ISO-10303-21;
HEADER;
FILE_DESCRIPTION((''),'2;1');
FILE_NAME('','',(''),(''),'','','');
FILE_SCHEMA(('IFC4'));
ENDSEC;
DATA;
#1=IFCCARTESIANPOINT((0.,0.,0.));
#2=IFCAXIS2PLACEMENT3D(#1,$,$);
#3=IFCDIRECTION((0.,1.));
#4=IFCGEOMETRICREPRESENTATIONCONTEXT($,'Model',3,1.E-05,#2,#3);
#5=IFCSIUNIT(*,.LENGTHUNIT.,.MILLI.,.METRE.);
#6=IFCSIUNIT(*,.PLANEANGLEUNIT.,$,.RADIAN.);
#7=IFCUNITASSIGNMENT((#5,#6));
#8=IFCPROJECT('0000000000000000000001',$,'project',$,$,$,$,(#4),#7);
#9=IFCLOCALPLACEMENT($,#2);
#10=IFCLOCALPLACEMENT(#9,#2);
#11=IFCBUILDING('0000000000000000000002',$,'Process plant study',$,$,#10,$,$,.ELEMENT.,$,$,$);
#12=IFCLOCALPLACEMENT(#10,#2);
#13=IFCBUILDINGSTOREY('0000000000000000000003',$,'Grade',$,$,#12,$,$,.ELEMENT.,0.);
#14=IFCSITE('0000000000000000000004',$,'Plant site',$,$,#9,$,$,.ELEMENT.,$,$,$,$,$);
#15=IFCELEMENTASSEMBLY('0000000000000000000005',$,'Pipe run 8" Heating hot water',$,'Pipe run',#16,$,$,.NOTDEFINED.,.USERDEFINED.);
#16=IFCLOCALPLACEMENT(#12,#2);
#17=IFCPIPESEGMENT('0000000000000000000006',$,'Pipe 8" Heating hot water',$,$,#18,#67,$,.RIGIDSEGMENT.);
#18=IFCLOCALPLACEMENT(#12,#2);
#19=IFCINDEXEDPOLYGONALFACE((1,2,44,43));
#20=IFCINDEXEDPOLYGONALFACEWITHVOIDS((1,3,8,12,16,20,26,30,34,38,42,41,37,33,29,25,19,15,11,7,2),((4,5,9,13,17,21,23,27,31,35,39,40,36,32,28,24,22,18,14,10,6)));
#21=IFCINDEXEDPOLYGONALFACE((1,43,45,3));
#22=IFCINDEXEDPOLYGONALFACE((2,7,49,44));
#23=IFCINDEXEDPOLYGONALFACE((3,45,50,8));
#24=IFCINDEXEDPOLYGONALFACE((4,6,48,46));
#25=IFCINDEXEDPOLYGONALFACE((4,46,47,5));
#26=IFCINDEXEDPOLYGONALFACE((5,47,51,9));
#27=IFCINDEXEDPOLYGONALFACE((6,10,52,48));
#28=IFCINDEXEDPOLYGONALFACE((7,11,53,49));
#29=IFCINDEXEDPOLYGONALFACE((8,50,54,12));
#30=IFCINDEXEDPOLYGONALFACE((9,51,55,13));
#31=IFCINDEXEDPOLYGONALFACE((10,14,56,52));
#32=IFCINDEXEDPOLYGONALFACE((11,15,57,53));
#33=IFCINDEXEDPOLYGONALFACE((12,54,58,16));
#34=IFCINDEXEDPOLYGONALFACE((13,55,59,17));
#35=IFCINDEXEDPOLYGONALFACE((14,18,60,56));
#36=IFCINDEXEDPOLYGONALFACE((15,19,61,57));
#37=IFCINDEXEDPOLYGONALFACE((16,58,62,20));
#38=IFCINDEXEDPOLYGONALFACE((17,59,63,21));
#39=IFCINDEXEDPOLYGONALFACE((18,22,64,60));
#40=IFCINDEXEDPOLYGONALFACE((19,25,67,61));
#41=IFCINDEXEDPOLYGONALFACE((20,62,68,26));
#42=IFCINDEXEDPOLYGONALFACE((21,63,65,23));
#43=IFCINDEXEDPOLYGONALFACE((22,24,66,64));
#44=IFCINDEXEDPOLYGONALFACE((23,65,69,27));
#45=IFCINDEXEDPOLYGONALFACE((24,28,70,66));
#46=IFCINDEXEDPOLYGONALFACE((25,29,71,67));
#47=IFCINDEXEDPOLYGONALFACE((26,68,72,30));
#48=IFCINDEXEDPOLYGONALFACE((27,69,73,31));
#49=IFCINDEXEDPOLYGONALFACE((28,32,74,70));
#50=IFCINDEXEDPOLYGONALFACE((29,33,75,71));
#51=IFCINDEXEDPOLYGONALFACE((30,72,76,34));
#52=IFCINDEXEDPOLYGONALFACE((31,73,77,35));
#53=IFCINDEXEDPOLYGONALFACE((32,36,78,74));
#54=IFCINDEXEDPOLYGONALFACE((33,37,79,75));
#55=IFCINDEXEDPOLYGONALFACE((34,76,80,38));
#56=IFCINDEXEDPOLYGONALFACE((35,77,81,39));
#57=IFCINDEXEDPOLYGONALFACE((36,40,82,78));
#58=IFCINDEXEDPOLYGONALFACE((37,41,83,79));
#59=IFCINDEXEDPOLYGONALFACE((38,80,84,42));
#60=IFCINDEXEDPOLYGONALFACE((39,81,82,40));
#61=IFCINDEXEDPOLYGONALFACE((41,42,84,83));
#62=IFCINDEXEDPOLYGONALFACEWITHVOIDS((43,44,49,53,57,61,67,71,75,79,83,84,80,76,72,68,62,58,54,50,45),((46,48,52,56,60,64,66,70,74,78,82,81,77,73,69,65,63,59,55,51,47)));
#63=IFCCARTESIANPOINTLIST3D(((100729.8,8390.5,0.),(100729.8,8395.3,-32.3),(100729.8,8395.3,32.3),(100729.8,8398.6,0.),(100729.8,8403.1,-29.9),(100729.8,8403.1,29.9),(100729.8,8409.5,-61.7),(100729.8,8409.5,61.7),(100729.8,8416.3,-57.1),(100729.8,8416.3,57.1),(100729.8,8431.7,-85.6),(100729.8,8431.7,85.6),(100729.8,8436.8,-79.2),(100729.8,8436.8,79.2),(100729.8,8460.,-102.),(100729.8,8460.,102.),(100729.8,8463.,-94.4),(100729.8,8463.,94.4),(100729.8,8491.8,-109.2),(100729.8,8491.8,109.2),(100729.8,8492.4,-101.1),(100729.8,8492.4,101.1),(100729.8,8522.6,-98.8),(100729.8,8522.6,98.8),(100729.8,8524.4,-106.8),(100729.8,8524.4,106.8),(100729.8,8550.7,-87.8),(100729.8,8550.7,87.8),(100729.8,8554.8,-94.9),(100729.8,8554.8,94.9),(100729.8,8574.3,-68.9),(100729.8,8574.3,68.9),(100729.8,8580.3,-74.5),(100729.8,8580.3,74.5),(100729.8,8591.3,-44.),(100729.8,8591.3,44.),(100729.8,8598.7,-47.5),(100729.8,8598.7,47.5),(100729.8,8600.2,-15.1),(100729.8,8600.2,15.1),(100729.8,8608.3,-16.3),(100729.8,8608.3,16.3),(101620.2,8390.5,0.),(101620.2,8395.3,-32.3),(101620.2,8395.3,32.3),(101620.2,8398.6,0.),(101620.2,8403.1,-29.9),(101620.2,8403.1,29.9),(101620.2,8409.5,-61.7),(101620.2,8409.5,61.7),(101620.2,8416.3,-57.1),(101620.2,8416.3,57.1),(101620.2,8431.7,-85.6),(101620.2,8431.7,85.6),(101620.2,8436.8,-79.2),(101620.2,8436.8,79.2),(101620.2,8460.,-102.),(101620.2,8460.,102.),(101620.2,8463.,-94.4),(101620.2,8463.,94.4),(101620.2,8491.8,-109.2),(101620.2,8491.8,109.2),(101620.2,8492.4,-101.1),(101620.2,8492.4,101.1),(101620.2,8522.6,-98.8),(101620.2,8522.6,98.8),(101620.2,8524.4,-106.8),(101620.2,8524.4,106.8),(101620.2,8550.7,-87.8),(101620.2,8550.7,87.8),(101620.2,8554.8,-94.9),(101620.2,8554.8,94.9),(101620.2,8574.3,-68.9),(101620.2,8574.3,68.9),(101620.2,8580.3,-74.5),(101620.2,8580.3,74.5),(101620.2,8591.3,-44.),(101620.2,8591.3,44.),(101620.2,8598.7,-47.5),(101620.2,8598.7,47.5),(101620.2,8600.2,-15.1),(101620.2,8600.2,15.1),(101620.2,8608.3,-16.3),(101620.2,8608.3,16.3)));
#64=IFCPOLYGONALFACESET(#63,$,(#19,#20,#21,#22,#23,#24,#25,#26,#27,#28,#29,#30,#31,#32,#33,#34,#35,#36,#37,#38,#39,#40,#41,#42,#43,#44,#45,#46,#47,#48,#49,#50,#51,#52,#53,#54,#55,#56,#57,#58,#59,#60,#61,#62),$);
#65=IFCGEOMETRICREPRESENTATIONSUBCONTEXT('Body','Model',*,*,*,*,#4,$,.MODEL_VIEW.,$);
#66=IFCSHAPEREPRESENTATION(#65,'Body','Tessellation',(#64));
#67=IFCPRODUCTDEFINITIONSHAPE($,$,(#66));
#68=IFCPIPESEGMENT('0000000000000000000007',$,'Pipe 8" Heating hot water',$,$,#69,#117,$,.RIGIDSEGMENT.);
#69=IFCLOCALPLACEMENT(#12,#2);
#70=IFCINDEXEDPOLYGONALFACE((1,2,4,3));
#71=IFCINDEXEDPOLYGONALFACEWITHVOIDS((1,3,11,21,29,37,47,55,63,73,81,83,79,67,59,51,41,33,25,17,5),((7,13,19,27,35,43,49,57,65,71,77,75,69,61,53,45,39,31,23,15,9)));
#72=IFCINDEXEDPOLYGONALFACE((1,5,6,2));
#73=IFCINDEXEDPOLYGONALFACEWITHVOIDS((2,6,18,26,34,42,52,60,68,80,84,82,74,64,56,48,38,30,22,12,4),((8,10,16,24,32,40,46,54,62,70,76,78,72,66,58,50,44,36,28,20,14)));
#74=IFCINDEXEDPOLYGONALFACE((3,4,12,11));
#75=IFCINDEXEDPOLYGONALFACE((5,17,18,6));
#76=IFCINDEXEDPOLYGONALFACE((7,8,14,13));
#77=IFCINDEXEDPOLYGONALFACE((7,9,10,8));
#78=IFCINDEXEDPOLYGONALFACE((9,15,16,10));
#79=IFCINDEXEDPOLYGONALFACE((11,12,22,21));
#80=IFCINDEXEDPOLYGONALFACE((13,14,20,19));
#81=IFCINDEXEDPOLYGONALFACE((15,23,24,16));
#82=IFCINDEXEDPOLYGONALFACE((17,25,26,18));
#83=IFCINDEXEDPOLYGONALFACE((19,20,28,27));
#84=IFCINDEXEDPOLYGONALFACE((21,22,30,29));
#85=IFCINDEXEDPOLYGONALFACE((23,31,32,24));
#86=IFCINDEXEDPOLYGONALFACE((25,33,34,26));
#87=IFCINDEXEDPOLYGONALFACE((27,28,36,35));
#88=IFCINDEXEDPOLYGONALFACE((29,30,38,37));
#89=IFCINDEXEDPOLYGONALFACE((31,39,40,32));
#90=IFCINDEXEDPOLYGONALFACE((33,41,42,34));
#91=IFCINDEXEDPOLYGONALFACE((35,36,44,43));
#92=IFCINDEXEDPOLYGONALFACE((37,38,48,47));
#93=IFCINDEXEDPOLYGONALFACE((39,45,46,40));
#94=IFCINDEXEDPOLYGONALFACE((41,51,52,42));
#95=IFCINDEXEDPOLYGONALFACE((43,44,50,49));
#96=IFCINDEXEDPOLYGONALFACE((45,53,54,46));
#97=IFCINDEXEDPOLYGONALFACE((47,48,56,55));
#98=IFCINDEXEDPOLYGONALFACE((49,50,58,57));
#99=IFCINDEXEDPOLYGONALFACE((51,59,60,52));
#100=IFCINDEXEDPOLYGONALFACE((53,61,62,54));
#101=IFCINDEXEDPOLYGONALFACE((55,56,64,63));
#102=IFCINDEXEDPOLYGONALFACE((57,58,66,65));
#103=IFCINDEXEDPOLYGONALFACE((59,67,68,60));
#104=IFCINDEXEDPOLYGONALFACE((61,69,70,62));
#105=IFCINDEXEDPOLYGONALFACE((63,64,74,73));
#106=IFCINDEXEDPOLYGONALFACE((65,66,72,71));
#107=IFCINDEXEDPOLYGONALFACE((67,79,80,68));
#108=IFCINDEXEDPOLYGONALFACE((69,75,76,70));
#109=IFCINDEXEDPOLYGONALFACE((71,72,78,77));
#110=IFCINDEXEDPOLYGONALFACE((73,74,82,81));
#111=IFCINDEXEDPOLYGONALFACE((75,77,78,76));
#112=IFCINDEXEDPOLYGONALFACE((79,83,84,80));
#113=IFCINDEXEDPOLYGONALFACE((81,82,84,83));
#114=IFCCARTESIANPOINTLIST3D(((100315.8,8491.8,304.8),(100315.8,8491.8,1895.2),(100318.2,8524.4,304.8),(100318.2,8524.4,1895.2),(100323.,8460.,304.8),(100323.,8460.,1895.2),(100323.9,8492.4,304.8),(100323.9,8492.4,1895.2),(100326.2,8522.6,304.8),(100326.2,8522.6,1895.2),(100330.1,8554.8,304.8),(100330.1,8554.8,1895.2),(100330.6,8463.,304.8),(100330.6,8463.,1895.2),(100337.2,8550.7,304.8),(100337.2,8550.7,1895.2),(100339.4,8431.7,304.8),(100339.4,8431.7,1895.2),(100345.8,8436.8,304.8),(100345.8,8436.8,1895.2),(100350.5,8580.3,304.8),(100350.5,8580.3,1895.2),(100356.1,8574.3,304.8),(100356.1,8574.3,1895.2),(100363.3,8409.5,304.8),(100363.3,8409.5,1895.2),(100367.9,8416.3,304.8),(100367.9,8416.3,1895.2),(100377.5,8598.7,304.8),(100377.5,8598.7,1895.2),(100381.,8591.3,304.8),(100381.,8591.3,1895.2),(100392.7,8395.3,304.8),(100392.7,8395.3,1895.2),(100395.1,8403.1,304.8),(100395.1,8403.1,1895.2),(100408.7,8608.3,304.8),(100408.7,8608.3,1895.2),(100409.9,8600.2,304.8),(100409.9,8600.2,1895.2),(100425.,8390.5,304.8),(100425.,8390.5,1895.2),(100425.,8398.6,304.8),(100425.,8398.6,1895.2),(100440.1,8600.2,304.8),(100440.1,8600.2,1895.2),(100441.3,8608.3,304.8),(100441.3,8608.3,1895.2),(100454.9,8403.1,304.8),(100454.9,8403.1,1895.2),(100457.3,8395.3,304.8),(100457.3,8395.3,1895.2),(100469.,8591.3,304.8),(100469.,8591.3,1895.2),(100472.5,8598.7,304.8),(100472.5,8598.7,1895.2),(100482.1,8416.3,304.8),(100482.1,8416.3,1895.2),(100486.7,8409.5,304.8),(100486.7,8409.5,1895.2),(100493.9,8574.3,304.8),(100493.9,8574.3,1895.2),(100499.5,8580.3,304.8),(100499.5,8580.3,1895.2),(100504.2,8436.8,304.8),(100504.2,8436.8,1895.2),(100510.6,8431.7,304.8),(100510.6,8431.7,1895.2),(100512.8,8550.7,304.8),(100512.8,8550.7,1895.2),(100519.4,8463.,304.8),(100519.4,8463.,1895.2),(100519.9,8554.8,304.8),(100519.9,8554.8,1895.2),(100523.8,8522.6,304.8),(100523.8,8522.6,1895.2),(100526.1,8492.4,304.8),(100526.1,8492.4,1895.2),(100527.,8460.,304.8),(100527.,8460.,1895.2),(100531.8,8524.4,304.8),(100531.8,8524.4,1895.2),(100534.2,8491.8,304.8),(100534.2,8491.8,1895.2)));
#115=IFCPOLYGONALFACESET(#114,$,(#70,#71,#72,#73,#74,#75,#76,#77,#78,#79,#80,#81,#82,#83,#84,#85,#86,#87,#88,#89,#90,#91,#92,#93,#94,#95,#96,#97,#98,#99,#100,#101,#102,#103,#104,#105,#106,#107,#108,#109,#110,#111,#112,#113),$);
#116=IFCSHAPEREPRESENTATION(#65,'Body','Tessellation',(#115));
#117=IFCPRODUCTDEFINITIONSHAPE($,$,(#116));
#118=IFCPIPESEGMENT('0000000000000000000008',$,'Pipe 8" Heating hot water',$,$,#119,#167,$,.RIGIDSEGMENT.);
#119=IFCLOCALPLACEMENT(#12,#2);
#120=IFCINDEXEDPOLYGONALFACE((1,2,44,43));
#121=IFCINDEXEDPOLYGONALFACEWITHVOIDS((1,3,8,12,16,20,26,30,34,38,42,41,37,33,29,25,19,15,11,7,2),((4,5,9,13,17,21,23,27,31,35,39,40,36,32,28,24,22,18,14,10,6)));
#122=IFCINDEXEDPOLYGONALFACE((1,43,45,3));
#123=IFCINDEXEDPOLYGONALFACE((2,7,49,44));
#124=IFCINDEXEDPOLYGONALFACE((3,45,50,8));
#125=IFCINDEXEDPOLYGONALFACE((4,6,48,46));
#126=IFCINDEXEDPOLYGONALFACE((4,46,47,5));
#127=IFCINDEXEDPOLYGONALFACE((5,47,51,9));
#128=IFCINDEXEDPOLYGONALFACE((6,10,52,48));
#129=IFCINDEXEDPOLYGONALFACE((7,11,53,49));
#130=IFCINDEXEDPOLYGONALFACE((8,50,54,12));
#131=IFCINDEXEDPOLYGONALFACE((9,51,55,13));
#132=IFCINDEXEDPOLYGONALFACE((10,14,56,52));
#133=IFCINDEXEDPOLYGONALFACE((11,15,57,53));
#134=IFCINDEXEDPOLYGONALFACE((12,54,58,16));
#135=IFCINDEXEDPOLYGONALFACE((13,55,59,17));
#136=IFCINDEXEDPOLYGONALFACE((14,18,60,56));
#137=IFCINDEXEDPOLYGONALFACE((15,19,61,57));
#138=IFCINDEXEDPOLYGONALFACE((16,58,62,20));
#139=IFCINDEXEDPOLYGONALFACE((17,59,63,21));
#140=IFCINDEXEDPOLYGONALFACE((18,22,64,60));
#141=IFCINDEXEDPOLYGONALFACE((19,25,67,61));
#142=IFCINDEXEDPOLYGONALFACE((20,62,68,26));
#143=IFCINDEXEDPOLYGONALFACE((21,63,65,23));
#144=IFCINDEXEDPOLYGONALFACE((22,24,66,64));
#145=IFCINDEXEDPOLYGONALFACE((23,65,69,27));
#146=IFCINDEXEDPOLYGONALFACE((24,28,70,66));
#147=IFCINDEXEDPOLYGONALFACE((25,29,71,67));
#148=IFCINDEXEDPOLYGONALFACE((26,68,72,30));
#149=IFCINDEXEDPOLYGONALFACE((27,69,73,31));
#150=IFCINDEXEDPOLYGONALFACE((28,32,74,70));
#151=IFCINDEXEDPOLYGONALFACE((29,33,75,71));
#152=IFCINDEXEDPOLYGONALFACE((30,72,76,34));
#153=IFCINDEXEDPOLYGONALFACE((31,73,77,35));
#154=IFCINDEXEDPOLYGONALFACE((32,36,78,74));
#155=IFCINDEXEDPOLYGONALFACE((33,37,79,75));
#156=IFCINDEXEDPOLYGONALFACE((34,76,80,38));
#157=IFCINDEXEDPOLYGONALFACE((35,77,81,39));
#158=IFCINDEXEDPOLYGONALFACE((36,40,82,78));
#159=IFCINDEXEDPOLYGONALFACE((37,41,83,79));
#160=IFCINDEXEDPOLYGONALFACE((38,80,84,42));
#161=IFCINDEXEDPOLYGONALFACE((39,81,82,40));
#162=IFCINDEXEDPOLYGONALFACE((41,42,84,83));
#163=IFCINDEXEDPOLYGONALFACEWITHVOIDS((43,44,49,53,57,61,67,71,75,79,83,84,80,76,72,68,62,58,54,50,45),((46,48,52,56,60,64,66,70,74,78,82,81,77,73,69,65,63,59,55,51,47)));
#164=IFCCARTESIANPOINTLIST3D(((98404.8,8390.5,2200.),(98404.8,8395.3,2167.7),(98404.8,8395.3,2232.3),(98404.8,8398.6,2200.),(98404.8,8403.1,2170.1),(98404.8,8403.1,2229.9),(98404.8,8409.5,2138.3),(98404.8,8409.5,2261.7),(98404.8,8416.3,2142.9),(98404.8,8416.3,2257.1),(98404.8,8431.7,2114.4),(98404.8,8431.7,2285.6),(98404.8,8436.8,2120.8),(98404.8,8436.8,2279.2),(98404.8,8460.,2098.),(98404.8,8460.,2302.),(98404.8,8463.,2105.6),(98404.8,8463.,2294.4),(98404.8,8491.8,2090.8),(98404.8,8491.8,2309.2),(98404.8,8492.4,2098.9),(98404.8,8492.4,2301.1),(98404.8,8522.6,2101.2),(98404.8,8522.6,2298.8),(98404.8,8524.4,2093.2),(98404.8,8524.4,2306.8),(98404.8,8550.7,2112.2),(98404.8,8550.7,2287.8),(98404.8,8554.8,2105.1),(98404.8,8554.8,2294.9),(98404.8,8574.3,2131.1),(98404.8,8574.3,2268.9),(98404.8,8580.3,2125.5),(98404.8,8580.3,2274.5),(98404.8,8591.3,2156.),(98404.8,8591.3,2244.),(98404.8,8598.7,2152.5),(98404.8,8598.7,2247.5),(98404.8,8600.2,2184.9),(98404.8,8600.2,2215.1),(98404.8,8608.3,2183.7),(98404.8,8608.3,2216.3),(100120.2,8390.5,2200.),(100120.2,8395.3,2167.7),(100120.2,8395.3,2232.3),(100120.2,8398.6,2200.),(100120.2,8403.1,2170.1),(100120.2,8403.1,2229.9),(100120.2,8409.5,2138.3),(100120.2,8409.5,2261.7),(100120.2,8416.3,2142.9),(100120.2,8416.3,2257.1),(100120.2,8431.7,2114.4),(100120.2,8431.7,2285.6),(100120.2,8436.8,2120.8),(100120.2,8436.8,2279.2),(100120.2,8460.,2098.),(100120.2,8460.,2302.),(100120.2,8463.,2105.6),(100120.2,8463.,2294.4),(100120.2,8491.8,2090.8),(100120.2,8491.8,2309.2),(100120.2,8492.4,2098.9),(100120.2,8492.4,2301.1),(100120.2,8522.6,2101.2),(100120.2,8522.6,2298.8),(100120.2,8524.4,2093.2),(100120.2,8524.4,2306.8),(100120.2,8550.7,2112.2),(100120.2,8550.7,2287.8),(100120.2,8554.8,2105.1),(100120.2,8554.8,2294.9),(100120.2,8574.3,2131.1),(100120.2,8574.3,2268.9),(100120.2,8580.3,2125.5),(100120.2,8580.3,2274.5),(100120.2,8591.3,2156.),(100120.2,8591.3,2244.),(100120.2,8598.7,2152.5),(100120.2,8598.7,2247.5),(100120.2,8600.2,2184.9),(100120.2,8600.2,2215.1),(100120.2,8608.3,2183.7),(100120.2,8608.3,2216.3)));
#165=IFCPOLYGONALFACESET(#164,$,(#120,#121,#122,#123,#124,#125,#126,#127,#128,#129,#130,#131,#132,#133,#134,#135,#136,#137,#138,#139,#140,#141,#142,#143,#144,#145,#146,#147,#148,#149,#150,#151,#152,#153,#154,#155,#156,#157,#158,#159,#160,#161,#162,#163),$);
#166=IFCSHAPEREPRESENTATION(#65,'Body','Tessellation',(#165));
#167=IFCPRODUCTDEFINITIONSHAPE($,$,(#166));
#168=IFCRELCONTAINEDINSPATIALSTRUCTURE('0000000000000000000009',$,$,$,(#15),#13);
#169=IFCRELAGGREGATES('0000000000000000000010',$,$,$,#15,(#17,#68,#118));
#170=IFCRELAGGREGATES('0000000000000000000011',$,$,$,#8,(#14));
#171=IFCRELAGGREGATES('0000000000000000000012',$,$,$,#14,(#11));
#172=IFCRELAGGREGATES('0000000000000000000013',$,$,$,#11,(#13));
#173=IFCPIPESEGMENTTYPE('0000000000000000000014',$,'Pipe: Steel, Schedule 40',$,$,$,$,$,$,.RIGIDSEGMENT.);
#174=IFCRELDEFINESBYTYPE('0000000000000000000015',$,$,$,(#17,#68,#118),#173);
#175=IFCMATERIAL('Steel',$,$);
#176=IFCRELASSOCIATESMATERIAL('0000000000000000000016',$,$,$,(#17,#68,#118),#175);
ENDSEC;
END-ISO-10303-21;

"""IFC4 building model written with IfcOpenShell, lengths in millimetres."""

from ifc_helpers import new_model, si_unit, direction, frame, origin, origin_with_axes, origin_2d, place, context, subcontext, project, spatial, hollow_circle, extrude, material, type_object, element, aggregate, save


model = new_model("IFC4")

# Units and contexts
model_context = context("Model", 3, precision=1e-05, world=origin(), true_north=direction((0.0, 1.0)))
body_context = subcontext(model_context, "Body", "Model", "MODEL_VIEW")
ifc_project = project(units=[si_unit("LENGTHUNIT", "METRE", prefix="MILLI"), si_unit("PLANEANGLEUNIT", "RADIAN")], contexts=[model_context])

# Site, building, storey
site_placement = place(None, origin())
site = spatial("IfcSite", under=ifc_project, at=site_placement, Name="Plant site", CompositionType="ELEMENT")
building_placement = place(site_placement, origin())
building = spatial("IfcBuilding", under=site, at=building_placement, Name="Process plant study", CompositionType="ELEMENT")
storey_placement = place(building_placement, origin())
storey = spatial("IfcBuildingStorey", under=building, at=storey_placement, Name="Grade", CompositionType="ELEMENT", Elevation=0.0)

# Element assembly, pipe segments
assembly_1_placement = place(storey_placement, origin_with_axes())
assembly_1 = element("IfcElementAssembly", 1, at=assembly_1_placement, inside=storey, Name="Pipe run 8\" Heating hot water", ObjectType="Pipe run", AssemblyPlace="NOTDEFINED", PredefinedType="USERDEFINED")
ifc_material = material(Name="Steel")
pipe_segment_type = type_object("IfcPipeSegmentType", Name="Pipe: Steel, Schedule 40", PredefinedType="RIGIDSEGMENT")
pipe_segment_1_placement = place(storey_placement, origin_with_axes())
pipe_segment_1 = element("IfcPipeSegment", 2, at=pipe_segment_1_placement, type_object=pipe_segment_type, material=ifc_material, Name="Pipe 8\" Heating hot water", PredefinedType="RIGIDSEGMENT", context=body_context, shape_type="SweptSolid", body=[
    extrude(hollow_circle(Radius=109.5, WallThickness=8.2, at=origin_2d()), frame((101620.2, 8500.0, 0.0), z_axis=(-1.0, 0.0, 0.0), x_axis=(0.0, -1.0, 0.0)), (0.0, 0.0, 1.0), 890.4),
])
pipe_segment_2_placement = place(storey_placement, origin_with_axes())
pipe_segment_2 = element("IfcPipeSegment", 3, at=pipe_segment_2_placement, type_object=pipe_segment_type, material=ifc_material, Name="Pipe 8\" Heating hot water", PredefinedType="RIGIDSEGMENT", context=body_context, shape_type="SweptSolid", body=[
    extrude(hollow_circle(Radius=109.5, WallThickness=8.2, at=origin_2d()), frame((100425.0, 8500.0, 304.8), z_axis=(0.0, 0.0, 1.0), x_axis=(0.0, -1.0, 0.0)), (0.0, 0.0, 1.0), 1590.4),
])
pipe_segment_3_placement = place(storey_placement, origin_with_axes())
pipe_segment_3 = element("IfcPipeSegment", 4, at=pipe_segment_3_placement, type_object=pipe_segment_type, material=ifc_material, Name="Pipe 8\" Heating hot water", PredefinedType="RIGIDSEGMENT", context=body_context, shape_type="SweptSolid", body=[
    extrude(hollow_circle(Radius=109.5, WallThickness=8.2, at=origin_2d()), frame((100120.2, 8500.0, 2200.0), z_axis=(-1.0, 0.0, 0.0), x_axis=(0.0, -1.0, 0.0)), (0.0, 0.0, 1.0), 1715.4),
])

aggregate(assembly_1, [pipe_segment_1, pipe_segment_2, pipe_segment_3])

save(model, "model.ifc")
